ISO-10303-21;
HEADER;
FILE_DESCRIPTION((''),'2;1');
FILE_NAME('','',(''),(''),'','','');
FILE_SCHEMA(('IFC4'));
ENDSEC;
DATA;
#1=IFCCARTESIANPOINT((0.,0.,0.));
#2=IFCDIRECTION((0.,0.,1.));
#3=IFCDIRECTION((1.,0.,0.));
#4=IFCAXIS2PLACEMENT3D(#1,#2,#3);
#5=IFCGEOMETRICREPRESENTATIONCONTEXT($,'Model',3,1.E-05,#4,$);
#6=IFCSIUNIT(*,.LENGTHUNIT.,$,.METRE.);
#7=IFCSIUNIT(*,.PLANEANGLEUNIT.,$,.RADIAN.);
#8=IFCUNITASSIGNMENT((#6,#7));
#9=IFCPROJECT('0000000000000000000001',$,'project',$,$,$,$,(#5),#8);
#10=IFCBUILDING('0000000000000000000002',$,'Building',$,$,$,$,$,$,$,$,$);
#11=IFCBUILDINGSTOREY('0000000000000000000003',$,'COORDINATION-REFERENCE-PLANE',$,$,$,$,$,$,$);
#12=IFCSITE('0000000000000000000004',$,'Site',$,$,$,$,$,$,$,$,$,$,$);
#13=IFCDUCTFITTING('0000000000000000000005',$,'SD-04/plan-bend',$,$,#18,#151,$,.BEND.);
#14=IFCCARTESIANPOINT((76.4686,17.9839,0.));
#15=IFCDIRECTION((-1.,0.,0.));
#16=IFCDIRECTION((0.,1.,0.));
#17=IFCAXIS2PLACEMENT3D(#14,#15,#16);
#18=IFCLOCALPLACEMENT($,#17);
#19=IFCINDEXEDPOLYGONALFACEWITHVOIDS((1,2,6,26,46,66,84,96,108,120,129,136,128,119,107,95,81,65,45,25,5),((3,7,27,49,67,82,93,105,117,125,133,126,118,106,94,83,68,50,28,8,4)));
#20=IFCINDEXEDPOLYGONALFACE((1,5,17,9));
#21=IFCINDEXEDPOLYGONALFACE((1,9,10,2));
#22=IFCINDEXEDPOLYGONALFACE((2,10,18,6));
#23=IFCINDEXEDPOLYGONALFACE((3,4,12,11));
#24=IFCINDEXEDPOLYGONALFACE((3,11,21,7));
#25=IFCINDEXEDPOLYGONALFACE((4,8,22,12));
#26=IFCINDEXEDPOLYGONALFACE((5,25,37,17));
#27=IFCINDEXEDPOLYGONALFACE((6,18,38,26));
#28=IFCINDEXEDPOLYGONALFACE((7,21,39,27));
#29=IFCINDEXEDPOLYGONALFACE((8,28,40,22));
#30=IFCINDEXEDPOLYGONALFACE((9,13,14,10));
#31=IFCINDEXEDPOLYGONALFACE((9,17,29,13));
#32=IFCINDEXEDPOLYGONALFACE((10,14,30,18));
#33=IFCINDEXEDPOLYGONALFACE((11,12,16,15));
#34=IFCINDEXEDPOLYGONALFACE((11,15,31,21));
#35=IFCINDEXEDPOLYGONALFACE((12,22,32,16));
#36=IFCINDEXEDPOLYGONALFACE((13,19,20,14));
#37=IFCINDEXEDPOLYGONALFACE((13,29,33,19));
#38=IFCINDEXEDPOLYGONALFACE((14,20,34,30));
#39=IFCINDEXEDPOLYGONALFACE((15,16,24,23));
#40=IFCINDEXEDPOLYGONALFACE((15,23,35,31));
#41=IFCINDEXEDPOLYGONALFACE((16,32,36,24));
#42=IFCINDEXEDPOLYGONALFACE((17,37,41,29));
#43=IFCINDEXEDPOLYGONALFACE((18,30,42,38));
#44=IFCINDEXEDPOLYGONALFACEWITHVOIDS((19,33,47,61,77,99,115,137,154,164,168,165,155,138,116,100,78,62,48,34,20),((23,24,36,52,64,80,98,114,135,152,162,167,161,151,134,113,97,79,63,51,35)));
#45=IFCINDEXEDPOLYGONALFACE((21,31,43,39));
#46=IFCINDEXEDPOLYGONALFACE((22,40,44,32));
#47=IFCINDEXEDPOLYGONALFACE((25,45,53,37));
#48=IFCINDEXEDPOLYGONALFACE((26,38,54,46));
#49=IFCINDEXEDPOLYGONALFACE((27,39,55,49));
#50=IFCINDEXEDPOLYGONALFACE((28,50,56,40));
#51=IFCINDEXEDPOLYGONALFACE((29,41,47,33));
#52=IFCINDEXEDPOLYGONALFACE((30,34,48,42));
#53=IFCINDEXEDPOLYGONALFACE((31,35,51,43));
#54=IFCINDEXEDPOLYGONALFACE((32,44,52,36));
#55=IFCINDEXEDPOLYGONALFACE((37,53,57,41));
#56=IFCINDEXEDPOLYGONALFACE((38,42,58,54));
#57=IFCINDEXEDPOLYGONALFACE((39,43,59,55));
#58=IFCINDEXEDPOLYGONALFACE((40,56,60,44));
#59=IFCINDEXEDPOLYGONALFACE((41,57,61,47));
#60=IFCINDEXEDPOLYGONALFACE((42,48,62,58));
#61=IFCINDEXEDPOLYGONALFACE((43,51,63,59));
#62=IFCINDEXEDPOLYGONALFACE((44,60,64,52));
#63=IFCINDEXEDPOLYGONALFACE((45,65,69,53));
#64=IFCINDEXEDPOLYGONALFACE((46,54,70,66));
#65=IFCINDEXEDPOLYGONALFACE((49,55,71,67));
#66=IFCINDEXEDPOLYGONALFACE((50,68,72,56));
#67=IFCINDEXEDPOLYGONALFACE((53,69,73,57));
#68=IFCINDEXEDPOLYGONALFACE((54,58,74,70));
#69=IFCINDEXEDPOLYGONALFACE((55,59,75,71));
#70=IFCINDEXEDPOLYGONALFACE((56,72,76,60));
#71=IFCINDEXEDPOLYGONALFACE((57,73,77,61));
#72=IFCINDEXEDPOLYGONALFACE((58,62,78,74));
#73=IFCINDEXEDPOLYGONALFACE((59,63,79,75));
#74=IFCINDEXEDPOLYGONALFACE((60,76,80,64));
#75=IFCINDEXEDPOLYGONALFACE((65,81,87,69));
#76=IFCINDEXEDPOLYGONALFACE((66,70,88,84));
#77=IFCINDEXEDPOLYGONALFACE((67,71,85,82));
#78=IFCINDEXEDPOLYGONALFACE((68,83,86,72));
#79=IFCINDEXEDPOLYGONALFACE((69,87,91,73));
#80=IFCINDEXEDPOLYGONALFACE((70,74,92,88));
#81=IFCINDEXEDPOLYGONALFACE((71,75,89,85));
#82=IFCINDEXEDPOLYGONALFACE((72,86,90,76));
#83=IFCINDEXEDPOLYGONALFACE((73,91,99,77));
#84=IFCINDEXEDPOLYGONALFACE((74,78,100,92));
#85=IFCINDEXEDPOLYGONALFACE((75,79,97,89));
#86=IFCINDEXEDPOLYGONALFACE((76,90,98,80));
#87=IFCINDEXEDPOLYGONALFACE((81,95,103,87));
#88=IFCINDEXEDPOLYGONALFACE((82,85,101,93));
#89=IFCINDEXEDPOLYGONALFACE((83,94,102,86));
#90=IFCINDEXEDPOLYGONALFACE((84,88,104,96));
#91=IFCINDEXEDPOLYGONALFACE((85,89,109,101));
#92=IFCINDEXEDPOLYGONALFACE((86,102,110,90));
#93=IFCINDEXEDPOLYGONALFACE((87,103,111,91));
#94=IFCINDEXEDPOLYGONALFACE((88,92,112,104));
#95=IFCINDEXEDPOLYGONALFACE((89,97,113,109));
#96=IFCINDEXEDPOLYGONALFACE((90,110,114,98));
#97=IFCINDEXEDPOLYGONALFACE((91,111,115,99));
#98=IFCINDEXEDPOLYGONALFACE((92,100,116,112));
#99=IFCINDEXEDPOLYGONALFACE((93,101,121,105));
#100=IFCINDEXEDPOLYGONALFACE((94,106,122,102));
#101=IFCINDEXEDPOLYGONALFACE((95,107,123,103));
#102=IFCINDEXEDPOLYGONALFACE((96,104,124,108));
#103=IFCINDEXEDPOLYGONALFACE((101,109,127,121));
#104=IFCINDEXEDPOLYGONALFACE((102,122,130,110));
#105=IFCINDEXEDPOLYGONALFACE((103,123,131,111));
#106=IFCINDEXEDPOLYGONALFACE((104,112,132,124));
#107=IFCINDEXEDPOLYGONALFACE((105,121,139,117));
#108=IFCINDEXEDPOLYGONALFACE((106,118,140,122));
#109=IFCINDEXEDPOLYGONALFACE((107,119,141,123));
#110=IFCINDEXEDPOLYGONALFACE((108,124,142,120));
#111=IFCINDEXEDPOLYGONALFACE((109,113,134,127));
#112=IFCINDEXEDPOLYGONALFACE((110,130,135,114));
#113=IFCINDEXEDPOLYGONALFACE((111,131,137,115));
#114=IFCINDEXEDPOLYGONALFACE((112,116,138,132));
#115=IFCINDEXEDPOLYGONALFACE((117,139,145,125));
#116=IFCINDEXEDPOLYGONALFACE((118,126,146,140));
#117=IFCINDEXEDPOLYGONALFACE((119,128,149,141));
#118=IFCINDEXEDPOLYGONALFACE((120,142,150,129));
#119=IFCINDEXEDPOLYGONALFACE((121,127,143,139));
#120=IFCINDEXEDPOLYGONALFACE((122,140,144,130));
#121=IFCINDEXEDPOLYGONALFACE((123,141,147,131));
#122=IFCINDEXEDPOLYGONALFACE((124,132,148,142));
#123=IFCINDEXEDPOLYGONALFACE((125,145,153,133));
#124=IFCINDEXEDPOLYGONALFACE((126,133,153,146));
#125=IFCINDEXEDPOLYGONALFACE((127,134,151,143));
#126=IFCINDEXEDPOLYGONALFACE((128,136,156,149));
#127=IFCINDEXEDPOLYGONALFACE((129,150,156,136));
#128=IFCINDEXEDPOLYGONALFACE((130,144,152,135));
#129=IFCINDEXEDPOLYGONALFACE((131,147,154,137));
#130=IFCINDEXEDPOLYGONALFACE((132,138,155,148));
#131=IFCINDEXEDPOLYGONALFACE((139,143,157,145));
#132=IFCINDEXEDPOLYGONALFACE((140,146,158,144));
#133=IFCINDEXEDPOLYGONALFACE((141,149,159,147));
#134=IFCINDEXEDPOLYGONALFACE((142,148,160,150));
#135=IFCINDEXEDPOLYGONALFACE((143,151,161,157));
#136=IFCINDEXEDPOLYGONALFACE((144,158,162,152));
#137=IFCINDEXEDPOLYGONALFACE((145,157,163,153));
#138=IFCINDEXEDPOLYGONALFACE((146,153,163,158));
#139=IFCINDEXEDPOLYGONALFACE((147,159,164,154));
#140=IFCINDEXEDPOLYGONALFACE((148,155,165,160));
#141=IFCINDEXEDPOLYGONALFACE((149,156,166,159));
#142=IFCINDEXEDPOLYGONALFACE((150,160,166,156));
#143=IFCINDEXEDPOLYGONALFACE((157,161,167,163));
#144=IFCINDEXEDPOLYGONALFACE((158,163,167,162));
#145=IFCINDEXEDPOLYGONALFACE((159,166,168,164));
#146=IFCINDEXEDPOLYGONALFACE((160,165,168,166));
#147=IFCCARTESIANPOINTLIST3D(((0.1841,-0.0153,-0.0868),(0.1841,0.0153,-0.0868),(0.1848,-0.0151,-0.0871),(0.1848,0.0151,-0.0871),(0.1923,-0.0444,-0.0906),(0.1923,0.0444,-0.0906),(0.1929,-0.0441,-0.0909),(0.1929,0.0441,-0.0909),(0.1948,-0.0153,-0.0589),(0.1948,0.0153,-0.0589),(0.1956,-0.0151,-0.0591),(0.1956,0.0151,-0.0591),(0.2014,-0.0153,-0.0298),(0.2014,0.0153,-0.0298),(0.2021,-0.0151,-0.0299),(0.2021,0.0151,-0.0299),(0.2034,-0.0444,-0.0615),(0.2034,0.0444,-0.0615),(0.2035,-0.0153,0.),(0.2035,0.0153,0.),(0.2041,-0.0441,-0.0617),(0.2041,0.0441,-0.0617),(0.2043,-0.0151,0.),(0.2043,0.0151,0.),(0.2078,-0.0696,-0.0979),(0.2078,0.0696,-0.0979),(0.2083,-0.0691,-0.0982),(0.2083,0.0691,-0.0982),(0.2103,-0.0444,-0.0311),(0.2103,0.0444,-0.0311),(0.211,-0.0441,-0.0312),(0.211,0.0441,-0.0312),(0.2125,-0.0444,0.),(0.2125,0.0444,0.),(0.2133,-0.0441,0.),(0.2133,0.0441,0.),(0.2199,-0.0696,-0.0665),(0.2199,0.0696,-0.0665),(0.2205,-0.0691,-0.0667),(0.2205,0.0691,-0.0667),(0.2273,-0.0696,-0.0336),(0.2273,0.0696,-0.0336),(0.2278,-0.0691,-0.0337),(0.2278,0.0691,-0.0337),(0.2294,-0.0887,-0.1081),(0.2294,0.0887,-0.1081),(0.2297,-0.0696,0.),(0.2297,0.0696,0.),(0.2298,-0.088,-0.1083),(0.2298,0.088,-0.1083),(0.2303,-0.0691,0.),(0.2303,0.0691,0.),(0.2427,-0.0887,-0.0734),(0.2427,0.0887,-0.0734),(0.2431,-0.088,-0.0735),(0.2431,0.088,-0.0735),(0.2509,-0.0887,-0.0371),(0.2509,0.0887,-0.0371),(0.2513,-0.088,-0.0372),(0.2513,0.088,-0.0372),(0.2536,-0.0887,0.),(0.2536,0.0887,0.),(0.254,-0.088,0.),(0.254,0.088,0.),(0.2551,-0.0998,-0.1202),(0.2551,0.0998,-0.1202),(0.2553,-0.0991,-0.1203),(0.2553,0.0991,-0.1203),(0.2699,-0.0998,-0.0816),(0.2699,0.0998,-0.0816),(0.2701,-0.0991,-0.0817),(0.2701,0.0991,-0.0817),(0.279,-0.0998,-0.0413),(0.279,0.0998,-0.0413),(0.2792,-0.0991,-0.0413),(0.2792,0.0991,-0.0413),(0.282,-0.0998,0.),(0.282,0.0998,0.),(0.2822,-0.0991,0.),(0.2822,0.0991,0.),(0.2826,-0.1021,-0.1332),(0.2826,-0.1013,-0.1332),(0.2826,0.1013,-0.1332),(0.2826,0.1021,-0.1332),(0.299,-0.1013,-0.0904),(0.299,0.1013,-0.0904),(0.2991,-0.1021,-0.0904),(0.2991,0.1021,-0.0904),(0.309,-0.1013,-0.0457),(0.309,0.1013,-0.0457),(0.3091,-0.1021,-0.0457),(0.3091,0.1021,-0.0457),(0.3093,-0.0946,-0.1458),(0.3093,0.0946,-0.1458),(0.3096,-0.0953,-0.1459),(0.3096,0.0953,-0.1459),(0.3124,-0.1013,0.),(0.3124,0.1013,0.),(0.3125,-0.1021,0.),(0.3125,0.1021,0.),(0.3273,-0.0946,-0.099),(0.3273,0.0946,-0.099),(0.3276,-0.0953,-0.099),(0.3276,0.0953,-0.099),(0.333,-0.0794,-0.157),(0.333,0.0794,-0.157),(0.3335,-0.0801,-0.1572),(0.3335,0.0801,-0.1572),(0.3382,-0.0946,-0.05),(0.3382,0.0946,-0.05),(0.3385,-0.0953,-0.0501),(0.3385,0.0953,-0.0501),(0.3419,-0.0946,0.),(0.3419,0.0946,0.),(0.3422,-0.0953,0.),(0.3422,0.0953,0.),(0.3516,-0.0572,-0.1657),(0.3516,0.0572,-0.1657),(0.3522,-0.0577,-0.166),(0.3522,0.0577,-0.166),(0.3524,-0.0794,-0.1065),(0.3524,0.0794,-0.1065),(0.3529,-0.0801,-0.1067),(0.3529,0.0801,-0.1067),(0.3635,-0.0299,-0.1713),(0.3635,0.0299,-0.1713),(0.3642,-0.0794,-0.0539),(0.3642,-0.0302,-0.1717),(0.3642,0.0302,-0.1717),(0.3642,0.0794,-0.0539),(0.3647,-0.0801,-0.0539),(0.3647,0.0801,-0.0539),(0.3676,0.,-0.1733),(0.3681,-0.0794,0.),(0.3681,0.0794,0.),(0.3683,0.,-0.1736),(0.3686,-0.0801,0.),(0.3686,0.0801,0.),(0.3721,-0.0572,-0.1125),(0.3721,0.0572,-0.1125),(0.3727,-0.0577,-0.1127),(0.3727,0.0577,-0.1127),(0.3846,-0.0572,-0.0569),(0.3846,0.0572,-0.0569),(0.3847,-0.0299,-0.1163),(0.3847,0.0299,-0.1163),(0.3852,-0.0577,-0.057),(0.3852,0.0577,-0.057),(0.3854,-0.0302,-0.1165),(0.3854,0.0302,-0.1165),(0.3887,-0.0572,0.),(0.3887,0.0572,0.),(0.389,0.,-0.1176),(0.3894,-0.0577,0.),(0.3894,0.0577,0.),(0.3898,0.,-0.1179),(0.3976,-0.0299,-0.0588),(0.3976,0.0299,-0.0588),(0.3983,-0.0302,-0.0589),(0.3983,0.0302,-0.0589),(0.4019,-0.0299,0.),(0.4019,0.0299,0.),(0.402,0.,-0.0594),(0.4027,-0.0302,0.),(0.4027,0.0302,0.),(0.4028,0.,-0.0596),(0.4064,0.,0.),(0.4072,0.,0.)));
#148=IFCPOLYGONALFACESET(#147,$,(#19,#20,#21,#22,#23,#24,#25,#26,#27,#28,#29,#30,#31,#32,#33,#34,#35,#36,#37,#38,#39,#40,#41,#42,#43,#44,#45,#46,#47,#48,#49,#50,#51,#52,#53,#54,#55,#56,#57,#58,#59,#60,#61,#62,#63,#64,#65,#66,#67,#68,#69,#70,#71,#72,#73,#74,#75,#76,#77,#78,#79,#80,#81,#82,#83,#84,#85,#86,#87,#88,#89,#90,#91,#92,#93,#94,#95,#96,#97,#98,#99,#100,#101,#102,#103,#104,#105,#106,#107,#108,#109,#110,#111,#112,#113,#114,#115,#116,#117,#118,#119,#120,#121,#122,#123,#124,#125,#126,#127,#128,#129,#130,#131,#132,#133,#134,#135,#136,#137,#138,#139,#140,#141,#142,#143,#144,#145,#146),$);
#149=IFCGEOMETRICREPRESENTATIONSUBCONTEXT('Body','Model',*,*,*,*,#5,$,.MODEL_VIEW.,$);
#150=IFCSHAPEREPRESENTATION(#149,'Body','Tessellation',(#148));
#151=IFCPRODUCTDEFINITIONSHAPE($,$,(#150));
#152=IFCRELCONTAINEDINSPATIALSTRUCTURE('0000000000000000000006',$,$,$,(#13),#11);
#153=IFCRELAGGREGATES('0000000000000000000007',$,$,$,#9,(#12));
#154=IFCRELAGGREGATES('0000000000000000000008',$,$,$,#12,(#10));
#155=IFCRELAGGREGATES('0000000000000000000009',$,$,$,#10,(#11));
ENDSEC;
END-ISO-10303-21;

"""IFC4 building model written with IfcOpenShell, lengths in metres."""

from ifc_helpers import new_model, entity, si_unit, frame, origin_with_axes, place, context, subcontext, project, spatial, element, save


model = new_model("IFC4")

# Units and contexts
model_context = context("Model", 3, precision=1e-05, world=origin_with_axes())
body_context_1 = subcontext(model_context, "Body", "Model", "MODEL_VIEW")
ifc_project = project(units=[si_unit("LENGTHUNIT", "METRE"), si_unit("PLANEANGLEUNIT", "RADIAN")], contexts=[model_context])

# Site, building, storey
site = spatial("IfcSite", under=ifc_project, Name="Site")
building = spatial("IfcBuilding", under=site, Name="Building")
storey = spatial("IfcBuildingStorey", under=building, Name="COORDINATION-REFERENCE-PLANE")

# Duct fitting
duct_fitting_1_placement = place(None, frame((76.4686, 17.9839, 0.0), z_axis=(-1.0, 0.0, 0.0), x_axis=(0.0, 1.0, 0.0)))
element("IfcDuctFitting", 1, at=duct_fitting_1_placement, inside=storey, Name="SD-04/plan-bend", PredefinedType="BEND", context=body_context_1, shape_type="SweptSolid", body=[
    entity("IfcRevolvedAreaSolid", entity("IfcCircleHollowProfileDef", "AREA", None, entity("IfcAxis2Placement2D", entity("IfcCartesianPoint", [0.3048, 0.0])), 0.1024, 0.0008), entity("IfcAxis2Placement3D", entity("IfcCartesianPoint", [0.0, 0.0, 0.0]), entity("IfcDirection", [0.0, 0.0, 1.0]), entity("IfcDirection", [1.0, 0.0, 0.0])), entity("IfcAxis1Placement", entity("IfcCartesianPoint", [0.0, 0.0, 0.0]), entity("IfcDirection", [0.0, 1.0, 0.0])), 0.440428),
])

save(model, "model.ifc")
